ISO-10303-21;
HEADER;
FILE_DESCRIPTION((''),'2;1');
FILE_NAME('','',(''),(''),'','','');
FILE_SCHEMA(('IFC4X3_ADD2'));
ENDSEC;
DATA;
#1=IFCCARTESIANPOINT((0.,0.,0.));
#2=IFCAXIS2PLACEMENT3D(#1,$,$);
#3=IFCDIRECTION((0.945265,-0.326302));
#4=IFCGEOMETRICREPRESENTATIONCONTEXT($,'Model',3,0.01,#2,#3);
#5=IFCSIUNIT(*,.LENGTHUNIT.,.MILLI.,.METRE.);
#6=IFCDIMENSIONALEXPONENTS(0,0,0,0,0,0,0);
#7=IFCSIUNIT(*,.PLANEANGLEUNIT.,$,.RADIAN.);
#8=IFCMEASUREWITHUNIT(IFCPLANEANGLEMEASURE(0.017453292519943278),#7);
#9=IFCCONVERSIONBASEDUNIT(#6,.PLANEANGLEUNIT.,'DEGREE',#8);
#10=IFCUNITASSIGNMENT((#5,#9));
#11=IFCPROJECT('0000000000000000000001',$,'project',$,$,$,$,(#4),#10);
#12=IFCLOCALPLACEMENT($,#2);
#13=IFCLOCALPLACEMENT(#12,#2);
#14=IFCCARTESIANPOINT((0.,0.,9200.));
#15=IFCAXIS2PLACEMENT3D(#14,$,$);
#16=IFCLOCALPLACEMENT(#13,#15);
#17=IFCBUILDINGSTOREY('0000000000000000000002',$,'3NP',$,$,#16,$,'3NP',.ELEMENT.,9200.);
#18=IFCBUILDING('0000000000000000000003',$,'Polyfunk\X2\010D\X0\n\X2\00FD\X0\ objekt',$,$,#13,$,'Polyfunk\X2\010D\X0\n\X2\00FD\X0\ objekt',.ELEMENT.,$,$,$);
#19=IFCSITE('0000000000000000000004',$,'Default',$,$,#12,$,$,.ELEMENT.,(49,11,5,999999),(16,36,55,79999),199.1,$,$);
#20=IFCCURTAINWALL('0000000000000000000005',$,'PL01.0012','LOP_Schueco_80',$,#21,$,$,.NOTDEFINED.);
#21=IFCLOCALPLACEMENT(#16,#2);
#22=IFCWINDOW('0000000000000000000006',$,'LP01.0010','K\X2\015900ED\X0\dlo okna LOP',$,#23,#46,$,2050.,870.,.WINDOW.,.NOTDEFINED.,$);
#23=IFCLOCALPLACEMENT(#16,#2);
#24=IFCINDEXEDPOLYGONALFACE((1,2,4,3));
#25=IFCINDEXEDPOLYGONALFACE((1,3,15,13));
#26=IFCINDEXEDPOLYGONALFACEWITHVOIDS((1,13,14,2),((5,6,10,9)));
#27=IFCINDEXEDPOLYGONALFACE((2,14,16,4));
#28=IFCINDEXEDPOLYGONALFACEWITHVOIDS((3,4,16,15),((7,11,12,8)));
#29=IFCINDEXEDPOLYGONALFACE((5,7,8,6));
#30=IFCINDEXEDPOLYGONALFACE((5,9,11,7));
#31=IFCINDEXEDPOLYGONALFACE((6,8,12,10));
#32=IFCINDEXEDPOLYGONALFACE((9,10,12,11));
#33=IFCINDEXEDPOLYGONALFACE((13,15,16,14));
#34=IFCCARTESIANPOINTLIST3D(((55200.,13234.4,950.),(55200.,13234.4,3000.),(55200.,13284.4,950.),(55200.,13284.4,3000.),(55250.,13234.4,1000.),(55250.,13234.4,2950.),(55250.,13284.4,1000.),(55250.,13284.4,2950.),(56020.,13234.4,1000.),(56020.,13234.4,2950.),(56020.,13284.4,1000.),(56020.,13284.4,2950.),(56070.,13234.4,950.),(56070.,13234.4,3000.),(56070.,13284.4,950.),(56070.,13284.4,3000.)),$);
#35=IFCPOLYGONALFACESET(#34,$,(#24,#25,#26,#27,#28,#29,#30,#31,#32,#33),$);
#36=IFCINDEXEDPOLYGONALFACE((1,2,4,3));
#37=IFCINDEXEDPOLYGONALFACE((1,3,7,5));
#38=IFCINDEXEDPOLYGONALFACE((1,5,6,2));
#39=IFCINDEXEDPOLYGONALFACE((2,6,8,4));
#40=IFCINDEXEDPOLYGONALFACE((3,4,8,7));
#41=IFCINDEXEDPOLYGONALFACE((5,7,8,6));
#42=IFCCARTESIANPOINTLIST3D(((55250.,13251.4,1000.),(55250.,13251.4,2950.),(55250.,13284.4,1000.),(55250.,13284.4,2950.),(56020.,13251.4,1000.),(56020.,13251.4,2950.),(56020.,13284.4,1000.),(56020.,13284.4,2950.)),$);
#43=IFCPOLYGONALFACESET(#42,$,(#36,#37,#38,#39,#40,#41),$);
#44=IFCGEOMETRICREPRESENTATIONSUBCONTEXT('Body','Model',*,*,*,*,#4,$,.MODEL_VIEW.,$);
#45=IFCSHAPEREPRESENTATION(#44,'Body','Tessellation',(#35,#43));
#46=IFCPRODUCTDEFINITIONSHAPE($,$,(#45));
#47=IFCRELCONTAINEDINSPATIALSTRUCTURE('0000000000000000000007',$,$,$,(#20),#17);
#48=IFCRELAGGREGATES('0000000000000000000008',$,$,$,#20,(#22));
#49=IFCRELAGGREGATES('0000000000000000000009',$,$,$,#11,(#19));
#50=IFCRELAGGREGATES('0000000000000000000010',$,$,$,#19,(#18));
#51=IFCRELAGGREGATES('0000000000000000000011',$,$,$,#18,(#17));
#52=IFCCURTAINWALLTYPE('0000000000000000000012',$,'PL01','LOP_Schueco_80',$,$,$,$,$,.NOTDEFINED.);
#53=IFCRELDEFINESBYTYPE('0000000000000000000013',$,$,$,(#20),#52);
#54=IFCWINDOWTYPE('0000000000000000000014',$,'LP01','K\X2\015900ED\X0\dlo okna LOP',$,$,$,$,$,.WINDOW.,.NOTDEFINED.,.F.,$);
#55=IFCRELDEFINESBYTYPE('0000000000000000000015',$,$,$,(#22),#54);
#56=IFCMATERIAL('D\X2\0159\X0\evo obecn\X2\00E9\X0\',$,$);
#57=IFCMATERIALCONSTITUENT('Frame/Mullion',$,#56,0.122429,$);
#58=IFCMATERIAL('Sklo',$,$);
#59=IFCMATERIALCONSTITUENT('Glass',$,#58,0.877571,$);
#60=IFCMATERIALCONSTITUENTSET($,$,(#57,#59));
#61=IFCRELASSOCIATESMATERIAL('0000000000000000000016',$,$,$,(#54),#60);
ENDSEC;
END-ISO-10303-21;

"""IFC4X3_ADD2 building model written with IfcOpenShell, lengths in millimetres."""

from ifc_helpers import new_model, entity, si_unit, converted_unit, direction, frame, origin, origin_2d_with_axis, place, context, subcontext, project, spatial, polyline, rectangle, outline, extrude, source, transform, mapped, material, constituent, constituent_set, type_object, type_shapes, element, aggregate, save


model = new_model("IFC4X3_ADD2")

# Units and contexts
model_context = context("Model", 3, precision=0.01, world=origin(), true_north=direction((0.945265, -0.326302)))
body_context = subcontext(model_context, "Body", "Model", "MODEL_VIEW")
ifc_project = project(units=[si_unit("LENGTHUNIT", "METRE", prefix="MILLI"), converted_unit("PLANEANGLEUNIT", "DEGREE", entity("IfcPlaneAngleMeasure", 0.017453292519943278), si_unit("PLANEANGLEUNIT", "RADIAN"), dimensions=[0, 0, 0, 0, 0, 0, 0])], contexts=[model_context])

# Site, building, storey
site_placement = place(None, origin())
site = spatial("IfcSite", under=ifc_project, at=site_placement, Name="Default", CompositionType="ELEMENT", RefLatitude=(49, 11, 5, 999999), RefLongitude=(16, 36, 55, 79999), RefElevation=199.1)
building_placement = place(site_placement, origin())
building = spatial("IfcBuilding", under=site, at=building_placement, Name="Polyfunkčný objekt", LongName="Polyfunkčný objekt", CompositionType="ELEMENT")
storey_placement = place(building_placement, frame((0.0, 0.0, 9200.0)))
storey = spatial("IfcBuildingStorey", under=building, at=storey_placement, Name="3NP", LongName="3NP", CompositionType="ELEMENT", Elevation=9200.0)

# Curtain wall, window
curtain_wall_type = type_object("IfcCurtainWallType", Name="PL01", Description="LOP_Schueco_80", PredefinedType="NOTDEFINED")
curtain_wall_placement = place(storey_placement, frame((0.0, 0.0, -9200.0)))
curtain_wall = element("IfcCurtainWall", 1, at=curtain_wall_placement, inside=storey, type_object=curtain_wall_type, Name="PL01.0012", Description="LOP_Schueco_80", PredefinedType="NOTDEFINED")
ifc_material_1 = material(Name="Sklo")
ifc_material_2 = material(Name="Dřevo obecné")
ifc_constituent_1 = constituent(ifc_material_2, Name="Frame/Mullion", fraction=0.122429)
ifc_constituent_2 = constituent(ifc_material_1, Name="Glass", fraction=0.877571)
ifc_constituent_set = constituent_set(constituents=[ifc_constituent_1, ifc_constituent_2])
window_type = type_object("IfcWindowType", Name="LP01", Description="Křídlo okna LOP", ParameterTakesPrecedence=False, PartitioningType="NOTDEFINED", PredefinedType="WINDOW", material=ifc_constituent_set)
shared_shape_1 = source(origin(), body_context, "Body", "SweptSolid", [
    extrude(outline(polyline([(-1025.0, -435.0), (1025.0, -435.0), (1025.0, 435.0), (-1025.0, 435.0), (-1025.0, -435.0)]), holes=[polyline([(-975.0, -385.0), (-975.0, 385.0), (975.0, 385.0), (975.0, -385.0), (-975.0, -385.0)])]), frame((0.0, 0.0, 1025.0), z_axis=(0.0, 1.0, 0.0), x_axis=(0.0, 0.0, -1.0)), (0.0, 0.0, 1.0), 50.0),
    extrude(rectangle(XDim=33.0, YDim=770.0, at=origin_2d_with_axis()), frame((0.0, 33.5, 50.0), z_axis=(0.0, 0.0, 1.0), x_axis=(0.0, -1.0, 0.0)), (0.0, 0.0, 1.0), 1950.0),
])
type_shapes(window_type, [shared_shape_1])
window_placement = place(curtain_wall_placement, frame((55635.0, 13234.4, 10150.0)))
window = element("IfcWindow", 2, at=window_placement, type_object=window_type, Name="LP01.0010", Description="Křídlo okna LOP", OverallHeight=2050.0, OverallWidth=870.0, PartitioningType="NOTDEFINED", PredefinedType="WINDOW", context=body_context, shape_type="MappedRepresentation", body=[
    mapped(shared_shape_1, transform((0.0, 0.0, 0.0), scale=1.0)),
])
aggregate(curtain_wall, [window])

save(model, "model.ifc")
